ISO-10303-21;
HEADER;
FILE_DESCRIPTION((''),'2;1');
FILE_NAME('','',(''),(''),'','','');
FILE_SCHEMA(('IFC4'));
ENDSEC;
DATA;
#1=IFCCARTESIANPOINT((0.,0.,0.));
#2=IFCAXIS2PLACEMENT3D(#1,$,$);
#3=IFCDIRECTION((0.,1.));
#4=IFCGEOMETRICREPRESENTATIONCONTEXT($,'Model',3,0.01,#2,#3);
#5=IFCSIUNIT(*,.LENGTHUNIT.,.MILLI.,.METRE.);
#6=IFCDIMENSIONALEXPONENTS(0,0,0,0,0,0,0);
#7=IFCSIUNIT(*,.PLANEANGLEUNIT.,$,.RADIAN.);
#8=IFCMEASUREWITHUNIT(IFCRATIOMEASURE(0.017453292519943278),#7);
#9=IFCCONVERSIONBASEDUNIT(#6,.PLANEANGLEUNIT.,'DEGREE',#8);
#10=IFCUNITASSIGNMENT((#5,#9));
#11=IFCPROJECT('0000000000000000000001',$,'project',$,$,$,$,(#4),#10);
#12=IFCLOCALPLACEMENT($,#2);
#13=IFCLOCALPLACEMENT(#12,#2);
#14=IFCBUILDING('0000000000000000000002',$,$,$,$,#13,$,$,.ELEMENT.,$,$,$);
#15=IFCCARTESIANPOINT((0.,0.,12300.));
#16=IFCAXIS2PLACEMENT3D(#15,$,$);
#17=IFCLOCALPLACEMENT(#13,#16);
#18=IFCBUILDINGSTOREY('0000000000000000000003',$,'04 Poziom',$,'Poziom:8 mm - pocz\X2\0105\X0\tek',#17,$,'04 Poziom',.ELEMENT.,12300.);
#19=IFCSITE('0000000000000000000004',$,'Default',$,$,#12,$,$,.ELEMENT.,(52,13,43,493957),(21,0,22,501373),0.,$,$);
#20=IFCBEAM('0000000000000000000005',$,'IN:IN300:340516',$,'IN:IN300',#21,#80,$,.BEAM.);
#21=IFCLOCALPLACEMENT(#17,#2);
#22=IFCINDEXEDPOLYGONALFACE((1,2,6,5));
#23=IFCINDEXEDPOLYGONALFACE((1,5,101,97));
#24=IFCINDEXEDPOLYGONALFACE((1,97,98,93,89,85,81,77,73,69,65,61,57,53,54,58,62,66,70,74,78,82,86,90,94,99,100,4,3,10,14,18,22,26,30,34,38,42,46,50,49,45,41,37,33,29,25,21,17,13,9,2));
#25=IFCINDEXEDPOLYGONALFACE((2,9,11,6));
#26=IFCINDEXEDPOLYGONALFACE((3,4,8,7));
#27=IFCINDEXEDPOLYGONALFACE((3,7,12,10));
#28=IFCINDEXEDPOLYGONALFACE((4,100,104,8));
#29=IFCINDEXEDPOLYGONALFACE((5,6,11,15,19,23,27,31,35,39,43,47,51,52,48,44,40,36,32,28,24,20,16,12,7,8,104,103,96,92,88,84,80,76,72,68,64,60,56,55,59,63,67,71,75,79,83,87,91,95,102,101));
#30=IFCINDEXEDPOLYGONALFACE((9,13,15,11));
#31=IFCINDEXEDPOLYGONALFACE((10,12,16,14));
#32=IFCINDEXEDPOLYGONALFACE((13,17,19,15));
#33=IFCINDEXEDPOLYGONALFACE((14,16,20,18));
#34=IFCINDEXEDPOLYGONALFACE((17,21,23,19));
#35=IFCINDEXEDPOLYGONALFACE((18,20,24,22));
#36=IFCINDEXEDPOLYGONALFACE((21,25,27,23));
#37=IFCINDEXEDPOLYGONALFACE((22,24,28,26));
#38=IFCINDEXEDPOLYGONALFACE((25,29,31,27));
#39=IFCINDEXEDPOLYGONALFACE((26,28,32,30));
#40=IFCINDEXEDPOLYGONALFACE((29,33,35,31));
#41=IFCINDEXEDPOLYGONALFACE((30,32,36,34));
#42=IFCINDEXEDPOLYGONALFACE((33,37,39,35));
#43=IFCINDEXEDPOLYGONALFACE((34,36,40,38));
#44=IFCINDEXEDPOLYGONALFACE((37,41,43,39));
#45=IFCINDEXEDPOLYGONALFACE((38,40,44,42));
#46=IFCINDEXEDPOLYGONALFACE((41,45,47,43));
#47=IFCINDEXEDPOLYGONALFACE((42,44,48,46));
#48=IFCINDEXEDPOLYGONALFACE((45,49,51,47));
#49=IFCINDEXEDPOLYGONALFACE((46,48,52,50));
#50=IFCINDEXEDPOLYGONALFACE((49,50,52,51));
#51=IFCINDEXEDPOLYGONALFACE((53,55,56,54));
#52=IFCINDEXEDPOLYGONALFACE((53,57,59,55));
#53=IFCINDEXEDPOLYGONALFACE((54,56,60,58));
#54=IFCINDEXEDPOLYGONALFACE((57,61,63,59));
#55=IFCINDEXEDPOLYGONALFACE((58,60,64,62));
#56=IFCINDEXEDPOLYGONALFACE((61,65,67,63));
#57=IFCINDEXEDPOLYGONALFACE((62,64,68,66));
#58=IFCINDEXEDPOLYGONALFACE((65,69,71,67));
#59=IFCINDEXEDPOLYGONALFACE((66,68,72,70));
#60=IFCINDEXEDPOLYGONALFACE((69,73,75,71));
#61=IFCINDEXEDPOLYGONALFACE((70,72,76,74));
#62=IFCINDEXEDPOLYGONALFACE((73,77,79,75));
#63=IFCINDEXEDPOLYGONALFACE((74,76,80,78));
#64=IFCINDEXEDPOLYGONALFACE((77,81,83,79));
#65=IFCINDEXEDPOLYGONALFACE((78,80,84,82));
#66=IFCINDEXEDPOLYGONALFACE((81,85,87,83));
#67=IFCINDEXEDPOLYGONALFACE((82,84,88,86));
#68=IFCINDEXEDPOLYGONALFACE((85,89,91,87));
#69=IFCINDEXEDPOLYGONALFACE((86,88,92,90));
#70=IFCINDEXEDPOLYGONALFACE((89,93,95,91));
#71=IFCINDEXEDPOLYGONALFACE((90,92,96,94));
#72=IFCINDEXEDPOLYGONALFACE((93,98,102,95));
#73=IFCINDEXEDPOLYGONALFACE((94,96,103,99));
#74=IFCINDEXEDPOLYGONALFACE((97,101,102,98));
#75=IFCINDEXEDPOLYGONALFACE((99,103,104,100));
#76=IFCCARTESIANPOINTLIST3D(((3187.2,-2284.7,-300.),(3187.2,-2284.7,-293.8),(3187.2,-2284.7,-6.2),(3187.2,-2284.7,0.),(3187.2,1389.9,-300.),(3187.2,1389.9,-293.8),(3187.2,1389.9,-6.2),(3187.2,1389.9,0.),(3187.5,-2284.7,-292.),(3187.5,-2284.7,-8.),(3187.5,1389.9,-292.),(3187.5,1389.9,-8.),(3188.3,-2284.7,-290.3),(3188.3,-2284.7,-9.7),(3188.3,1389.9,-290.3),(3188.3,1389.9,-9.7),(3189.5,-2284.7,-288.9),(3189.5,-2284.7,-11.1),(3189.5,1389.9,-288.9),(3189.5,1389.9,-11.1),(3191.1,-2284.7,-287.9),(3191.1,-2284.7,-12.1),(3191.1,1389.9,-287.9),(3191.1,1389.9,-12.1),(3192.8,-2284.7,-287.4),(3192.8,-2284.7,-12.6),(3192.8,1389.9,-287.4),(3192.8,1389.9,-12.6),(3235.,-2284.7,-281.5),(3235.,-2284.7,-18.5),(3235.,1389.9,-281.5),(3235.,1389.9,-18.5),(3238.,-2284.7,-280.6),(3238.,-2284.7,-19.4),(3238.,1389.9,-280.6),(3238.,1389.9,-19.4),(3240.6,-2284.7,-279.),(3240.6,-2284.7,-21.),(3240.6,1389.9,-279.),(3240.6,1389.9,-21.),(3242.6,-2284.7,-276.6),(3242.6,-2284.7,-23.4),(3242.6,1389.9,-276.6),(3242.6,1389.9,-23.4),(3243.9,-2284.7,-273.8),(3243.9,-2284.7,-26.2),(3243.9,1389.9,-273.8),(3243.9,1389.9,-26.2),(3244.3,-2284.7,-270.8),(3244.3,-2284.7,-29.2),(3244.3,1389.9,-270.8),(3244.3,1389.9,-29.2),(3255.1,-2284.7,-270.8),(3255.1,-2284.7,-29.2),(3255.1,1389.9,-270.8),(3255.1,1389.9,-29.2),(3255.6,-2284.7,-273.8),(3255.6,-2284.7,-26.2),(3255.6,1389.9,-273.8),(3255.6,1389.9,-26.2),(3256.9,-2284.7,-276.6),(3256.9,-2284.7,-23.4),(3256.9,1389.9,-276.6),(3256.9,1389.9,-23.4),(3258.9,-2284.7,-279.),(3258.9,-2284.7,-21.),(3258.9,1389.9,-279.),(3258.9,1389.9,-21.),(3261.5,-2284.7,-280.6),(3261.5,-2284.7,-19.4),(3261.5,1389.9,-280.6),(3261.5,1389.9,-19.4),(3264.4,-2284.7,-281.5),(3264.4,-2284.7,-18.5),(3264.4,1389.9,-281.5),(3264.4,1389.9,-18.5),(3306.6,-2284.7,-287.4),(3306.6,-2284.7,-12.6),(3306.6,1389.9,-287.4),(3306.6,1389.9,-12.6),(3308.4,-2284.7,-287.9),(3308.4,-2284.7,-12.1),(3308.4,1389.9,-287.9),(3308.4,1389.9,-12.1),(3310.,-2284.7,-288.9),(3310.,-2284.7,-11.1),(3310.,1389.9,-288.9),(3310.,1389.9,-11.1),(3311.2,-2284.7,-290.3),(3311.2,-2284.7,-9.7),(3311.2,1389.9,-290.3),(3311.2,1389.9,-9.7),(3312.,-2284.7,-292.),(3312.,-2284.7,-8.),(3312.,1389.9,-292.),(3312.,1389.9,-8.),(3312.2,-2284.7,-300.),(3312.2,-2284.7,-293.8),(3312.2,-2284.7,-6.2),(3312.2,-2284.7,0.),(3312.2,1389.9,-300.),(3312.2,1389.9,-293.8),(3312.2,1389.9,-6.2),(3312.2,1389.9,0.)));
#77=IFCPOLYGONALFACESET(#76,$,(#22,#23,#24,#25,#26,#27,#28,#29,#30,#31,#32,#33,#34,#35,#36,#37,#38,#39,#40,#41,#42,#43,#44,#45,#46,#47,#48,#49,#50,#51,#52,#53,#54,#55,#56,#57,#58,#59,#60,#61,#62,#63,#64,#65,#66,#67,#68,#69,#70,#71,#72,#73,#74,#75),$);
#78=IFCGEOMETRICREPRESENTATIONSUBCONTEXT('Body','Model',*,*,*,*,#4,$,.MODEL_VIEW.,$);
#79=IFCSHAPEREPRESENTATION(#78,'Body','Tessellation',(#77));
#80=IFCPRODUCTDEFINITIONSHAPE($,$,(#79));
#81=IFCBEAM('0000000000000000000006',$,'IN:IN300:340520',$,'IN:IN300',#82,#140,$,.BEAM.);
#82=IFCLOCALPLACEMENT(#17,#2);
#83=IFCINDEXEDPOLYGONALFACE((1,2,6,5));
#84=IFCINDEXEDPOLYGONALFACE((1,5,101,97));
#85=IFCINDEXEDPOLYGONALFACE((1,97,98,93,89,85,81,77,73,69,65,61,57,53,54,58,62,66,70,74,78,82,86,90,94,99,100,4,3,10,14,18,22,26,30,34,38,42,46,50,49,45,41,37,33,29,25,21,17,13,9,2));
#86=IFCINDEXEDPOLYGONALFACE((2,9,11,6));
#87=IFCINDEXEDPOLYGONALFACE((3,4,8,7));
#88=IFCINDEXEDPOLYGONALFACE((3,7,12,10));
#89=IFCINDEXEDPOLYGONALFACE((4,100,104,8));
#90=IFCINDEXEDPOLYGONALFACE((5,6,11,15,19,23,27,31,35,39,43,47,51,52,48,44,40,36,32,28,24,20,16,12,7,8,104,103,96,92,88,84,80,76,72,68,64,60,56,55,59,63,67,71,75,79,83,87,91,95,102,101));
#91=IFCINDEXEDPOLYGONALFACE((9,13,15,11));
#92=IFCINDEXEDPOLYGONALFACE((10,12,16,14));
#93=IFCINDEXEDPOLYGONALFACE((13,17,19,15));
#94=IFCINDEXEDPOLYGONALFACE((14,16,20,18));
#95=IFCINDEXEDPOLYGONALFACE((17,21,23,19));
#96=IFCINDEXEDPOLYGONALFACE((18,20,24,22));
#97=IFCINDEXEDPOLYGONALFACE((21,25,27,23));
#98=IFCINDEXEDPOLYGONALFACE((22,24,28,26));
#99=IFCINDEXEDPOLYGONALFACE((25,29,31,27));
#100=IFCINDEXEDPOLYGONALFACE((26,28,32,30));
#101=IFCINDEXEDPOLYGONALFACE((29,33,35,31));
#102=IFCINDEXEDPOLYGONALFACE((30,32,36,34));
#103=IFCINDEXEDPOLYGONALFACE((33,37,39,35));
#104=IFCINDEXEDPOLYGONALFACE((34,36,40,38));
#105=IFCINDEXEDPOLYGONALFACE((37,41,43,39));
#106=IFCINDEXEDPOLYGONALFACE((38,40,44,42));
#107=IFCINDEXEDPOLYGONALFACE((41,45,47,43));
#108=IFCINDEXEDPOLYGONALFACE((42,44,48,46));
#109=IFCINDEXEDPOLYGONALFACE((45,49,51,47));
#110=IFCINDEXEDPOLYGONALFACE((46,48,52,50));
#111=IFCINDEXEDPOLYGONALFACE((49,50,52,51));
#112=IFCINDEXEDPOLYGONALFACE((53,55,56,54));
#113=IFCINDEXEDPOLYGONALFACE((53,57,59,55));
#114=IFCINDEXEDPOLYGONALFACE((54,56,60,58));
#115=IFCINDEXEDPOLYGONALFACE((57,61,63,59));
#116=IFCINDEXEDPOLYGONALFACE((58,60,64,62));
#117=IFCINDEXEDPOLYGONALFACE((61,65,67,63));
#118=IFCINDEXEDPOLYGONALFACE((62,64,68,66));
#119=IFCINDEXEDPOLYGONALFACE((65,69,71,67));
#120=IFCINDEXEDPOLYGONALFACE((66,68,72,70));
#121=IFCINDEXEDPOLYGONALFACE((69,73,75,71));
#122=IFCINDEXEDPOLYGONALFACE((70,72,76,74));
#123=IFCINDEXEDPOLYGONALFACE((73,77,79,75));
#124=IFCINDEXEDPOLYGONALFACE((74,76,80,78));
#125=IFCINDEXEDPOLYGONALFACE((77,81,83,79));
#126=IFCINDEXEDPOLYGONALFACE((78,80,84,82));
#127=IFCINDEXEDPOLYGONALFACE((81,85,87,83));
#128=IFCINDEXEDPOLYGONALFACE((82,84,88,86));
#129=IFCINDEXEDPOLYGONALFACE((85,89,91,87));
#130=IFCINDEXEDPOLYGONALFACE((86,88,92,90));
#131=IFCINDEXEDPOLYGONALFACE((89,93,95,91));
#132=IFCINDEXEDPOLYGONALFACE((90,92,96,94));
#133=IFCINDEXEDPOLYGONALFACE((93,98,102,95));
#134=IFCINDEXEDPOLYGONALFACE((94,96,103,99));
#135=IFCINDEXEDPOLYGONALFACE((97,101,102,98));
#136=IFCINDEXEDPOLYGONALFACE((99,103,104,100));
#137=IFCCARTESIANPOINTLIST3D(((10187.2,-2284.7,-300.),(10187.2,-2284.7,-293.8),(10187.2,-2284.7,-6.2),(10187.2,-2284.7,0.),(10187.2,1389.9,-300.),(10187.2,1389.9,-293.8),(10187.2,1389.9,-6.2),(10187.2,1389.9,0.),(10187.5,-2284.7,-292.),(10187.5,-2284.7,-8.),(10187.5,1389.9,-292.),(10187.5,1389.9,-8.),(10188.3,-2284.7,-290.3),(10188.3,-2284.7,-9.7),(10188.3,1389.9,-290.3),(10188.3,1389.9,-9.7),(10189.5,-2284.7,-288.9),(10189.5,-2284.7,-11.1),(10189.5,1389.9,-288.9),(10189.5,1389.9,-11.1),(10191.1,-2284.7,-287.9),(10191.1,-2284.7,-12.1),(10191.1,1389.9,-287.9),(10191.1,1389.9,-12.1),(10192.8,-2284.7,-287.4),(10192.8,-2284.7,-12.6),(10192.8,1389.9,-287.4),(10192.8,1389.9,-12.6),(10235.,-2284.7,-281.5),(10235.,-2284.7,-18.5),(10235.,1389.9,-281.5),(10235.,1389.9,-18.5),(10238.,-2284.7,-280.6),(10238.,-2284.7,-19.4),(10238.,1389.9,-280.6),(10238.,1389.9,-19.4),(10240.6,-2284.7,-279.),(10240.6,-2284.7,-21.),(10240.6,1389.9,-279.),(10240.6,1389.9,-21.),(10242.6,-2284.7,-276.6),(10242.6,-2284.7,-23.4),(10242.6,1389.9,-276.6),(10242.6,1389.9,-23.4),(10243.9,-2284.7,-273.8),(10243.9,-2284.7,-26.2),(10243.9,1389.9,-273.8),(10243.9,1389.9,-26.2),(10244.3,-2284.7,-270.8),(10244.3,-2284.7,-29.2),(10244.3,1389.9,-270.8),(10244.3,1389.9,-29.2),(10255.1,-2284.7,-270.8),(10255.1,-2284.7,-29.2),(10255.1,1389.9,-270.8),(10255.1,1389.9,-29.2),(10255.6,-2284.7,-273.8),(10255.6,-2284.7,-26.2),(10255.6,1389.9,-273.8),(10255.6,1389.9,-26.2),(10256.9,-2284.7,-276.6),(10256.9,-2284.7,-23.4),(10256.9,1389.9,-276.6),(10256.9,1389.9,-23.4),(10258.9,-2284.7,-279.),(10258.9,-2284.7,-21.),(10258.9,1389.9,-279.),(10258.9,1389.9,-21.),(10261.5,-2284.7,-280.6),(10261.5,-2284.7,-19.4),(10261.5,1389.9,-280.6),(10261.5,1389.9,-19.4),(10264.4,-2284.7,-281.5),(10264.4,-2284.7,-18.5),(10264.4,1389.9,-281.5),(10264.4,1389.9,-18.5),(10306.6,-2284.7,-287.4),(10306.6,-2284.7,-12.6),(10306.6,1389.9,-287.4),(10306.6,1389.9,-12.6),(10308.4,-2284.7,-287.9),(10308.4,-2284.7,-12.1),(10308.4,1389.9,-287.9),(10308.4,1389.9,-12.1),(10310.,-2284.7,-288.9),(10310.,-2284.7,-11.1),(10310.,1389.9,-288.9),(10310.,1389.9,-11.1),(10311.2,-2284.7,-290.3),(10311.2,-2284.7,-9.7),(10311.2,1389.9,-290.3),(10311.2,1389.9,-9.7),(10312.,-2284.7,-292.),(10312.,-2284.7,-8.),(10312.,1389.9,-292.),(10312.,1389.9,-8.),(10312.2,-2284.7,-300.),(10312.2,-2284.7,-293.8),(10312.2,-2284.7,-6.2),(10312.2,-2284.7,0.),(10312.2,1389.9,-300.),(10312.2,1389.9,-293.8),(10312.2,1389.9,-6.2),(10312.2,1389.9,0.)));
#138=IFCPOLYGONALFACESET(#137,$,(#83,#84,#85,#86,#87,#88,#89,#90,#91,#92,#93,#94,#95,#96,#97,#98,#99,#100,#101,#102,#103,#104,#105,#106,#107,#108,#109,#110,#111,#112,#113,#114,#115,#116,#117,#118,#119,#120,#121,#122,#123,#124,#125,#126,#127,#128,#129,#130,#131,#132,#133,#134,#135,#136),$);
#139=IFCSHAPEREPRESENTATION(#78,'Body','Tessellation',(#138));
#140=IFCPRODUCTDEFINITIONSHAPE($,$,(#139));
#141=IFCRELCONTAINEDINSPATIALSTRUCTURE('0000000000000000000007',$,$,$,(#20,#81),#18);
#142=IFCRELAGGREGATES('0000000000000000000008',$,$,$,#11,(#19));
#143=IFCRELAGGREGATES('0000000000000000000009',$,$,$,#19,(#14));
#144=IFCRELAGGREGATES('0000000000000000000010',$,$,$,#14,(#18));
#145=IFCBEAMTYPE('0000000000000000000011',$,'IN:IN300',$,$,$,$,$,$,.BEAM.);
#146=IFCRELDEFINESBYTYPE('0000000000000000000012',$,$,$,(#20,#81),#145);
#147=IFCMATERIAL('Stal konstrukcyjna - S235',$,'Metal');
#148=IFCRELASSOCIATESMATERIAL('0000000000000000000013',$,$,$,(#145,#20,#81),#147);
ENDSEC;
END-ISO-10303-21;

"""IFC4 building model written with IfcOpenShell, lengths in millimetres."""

from ifc_helpers import new_model, entity, si_unit, converted_unit, direction, frame, origin, place, context, subcontext, project, spatial, line, arc, indexed_curve, outline, extrude, source, transform, mapped, material, type_object, type_shapes, element, save


model = new_model("IFC4")

# Units and contexts
model_context = context("Model", 3, precision=0.01, world=origin(), true_north=direction((0.0, 1.0)))
body_context = subcontext(model_context, "Body", "Model", "MODEL_VIEW")
ifc_project = project(units=[si_unit("LENGTHUNIT", "METRE", prefix="MILLI"), converted_unit("PLANEANGLEUNIT", "DEGREE", entity("IfcRatioMeasure", 0.017453292519943278), si_unit("PLANEANGLEUNIT", "RADIAN"), dimensions=[0, 0, 0, 0, 0, 0, 0])], contexts=[model_context])

# Site, building, storey
site_placement = place(None, origin())
site = spatial("IfcSite", under=ifc_project, at=site_placement, Name="Default", CompositionType="ELEMENT", RefLatitude=(52, 13, 43, 493957), RefLongitude=(21, 0, 22, 501373), RefElevation=0.0)
building_placement = place(site_placement, origin())
building = spatial("IfcBuilding", under=site, at=building_placement, CompositionType="ELEMENT")
storey_placement = place(building_placement, frame((0.0, 0.0, 12300.0)))
storey = spatial("IfcBuildingStorey", under=building, at=storey_placement, Name="04 Poziom", ObjectType="Poziom:8 mm - początek", LongName="04 Poziom", CompositionType="ELEMENT", Elevation=12300.0)

# Shared definitions
ifc_material_1 = material(Name="Stal konstrukcyjna - S235", Category="Metal")

# Beams
beam_type_1 = type_object("IfcBeamType", Name="IN:IN300", PredefinedType="BEAM", material=ifc_material_1)
shared_shape_1 = source(origin(), body_context, "Body", "SweptSolid", [
    extrude(outline(indexed_curve([(143.8, -62.5), (150.0, -62.5), (150.0, 62.5), (143.8, 62.5), (139.6, 60.9), (137.4, 56.9), (131.5, 14.7), (127.9, 8.1), (120.8, 5.4), (-120.8, 5.4), (-127.9, 8.1), (-131.5, 14.7), (-137.4, 56.9), (-139.6, 60.9), (-143.8, 62.5), (-150.0, 62.5), (-150.0, -62.5), (-143.8, -62.5), (-139.6, -60.9), (-137.4, -56.9), (-131.5, -14.7), (-127.9, -8.1), (-120.8, -5.4), (120.8, -5.4), (127.9, -8.1), (131.5, -14.7), (137.4, -56.9), (139.6, -60.9)], segments=[line(1, 2, 3, 4), arc(4, 5, 6), line(6, 7), arc(7, 8, 9), line(9, 10), arc(10, 11, 12), line(12, 13), arc(13, 14, 15), line(15, 16, 17, 18), arc(18, 19, 20), line(20, 21), arc(21, 22, 23), line(23, 24), arc(24, 25, 26), line(26, 27), arc(27, 28, 1)], self_intersect=False)), frame((-1837.3, 0.0, 0.0), z_axis=(1.0, 0.0, 0.0), x_axis=(0.0, 0.0, -1.0)), (0.0, 0.0, 1.0), 3674.6),
])
type_shapes(beam_type_1, [shared_shape_1])
for number, where, z_axis, x_axis, name in (
    (1, (3249.7, -447.4, -150.0), (0.0, 0.0, 1.0), (0.0, -1.0, 0.0), "IN:IN300:340516"),
    (2, (10249.7, -447.4, -150.0), (0.0, 0.0, 1.0), (0.0, -1.0, 0.0), "IN:IN300:340520"),
):
    element("IfcBeam", number, at=place(storey_placement, frame(where, z_axis=z_axis, x_axis=x_axis)), inside=storey, type_object=beam_type_1, material=ifc_material_1, Name=name, ObjectType="IN:IN300", PredefinedType="BEAM", context=body_context, shape_type="MappedRepresentation", body=[
        mapped(shared_shape_1, transform((0.0, 0.0, 0.0), scale=1.0)),
    ])

save(model, "model.ifc")
